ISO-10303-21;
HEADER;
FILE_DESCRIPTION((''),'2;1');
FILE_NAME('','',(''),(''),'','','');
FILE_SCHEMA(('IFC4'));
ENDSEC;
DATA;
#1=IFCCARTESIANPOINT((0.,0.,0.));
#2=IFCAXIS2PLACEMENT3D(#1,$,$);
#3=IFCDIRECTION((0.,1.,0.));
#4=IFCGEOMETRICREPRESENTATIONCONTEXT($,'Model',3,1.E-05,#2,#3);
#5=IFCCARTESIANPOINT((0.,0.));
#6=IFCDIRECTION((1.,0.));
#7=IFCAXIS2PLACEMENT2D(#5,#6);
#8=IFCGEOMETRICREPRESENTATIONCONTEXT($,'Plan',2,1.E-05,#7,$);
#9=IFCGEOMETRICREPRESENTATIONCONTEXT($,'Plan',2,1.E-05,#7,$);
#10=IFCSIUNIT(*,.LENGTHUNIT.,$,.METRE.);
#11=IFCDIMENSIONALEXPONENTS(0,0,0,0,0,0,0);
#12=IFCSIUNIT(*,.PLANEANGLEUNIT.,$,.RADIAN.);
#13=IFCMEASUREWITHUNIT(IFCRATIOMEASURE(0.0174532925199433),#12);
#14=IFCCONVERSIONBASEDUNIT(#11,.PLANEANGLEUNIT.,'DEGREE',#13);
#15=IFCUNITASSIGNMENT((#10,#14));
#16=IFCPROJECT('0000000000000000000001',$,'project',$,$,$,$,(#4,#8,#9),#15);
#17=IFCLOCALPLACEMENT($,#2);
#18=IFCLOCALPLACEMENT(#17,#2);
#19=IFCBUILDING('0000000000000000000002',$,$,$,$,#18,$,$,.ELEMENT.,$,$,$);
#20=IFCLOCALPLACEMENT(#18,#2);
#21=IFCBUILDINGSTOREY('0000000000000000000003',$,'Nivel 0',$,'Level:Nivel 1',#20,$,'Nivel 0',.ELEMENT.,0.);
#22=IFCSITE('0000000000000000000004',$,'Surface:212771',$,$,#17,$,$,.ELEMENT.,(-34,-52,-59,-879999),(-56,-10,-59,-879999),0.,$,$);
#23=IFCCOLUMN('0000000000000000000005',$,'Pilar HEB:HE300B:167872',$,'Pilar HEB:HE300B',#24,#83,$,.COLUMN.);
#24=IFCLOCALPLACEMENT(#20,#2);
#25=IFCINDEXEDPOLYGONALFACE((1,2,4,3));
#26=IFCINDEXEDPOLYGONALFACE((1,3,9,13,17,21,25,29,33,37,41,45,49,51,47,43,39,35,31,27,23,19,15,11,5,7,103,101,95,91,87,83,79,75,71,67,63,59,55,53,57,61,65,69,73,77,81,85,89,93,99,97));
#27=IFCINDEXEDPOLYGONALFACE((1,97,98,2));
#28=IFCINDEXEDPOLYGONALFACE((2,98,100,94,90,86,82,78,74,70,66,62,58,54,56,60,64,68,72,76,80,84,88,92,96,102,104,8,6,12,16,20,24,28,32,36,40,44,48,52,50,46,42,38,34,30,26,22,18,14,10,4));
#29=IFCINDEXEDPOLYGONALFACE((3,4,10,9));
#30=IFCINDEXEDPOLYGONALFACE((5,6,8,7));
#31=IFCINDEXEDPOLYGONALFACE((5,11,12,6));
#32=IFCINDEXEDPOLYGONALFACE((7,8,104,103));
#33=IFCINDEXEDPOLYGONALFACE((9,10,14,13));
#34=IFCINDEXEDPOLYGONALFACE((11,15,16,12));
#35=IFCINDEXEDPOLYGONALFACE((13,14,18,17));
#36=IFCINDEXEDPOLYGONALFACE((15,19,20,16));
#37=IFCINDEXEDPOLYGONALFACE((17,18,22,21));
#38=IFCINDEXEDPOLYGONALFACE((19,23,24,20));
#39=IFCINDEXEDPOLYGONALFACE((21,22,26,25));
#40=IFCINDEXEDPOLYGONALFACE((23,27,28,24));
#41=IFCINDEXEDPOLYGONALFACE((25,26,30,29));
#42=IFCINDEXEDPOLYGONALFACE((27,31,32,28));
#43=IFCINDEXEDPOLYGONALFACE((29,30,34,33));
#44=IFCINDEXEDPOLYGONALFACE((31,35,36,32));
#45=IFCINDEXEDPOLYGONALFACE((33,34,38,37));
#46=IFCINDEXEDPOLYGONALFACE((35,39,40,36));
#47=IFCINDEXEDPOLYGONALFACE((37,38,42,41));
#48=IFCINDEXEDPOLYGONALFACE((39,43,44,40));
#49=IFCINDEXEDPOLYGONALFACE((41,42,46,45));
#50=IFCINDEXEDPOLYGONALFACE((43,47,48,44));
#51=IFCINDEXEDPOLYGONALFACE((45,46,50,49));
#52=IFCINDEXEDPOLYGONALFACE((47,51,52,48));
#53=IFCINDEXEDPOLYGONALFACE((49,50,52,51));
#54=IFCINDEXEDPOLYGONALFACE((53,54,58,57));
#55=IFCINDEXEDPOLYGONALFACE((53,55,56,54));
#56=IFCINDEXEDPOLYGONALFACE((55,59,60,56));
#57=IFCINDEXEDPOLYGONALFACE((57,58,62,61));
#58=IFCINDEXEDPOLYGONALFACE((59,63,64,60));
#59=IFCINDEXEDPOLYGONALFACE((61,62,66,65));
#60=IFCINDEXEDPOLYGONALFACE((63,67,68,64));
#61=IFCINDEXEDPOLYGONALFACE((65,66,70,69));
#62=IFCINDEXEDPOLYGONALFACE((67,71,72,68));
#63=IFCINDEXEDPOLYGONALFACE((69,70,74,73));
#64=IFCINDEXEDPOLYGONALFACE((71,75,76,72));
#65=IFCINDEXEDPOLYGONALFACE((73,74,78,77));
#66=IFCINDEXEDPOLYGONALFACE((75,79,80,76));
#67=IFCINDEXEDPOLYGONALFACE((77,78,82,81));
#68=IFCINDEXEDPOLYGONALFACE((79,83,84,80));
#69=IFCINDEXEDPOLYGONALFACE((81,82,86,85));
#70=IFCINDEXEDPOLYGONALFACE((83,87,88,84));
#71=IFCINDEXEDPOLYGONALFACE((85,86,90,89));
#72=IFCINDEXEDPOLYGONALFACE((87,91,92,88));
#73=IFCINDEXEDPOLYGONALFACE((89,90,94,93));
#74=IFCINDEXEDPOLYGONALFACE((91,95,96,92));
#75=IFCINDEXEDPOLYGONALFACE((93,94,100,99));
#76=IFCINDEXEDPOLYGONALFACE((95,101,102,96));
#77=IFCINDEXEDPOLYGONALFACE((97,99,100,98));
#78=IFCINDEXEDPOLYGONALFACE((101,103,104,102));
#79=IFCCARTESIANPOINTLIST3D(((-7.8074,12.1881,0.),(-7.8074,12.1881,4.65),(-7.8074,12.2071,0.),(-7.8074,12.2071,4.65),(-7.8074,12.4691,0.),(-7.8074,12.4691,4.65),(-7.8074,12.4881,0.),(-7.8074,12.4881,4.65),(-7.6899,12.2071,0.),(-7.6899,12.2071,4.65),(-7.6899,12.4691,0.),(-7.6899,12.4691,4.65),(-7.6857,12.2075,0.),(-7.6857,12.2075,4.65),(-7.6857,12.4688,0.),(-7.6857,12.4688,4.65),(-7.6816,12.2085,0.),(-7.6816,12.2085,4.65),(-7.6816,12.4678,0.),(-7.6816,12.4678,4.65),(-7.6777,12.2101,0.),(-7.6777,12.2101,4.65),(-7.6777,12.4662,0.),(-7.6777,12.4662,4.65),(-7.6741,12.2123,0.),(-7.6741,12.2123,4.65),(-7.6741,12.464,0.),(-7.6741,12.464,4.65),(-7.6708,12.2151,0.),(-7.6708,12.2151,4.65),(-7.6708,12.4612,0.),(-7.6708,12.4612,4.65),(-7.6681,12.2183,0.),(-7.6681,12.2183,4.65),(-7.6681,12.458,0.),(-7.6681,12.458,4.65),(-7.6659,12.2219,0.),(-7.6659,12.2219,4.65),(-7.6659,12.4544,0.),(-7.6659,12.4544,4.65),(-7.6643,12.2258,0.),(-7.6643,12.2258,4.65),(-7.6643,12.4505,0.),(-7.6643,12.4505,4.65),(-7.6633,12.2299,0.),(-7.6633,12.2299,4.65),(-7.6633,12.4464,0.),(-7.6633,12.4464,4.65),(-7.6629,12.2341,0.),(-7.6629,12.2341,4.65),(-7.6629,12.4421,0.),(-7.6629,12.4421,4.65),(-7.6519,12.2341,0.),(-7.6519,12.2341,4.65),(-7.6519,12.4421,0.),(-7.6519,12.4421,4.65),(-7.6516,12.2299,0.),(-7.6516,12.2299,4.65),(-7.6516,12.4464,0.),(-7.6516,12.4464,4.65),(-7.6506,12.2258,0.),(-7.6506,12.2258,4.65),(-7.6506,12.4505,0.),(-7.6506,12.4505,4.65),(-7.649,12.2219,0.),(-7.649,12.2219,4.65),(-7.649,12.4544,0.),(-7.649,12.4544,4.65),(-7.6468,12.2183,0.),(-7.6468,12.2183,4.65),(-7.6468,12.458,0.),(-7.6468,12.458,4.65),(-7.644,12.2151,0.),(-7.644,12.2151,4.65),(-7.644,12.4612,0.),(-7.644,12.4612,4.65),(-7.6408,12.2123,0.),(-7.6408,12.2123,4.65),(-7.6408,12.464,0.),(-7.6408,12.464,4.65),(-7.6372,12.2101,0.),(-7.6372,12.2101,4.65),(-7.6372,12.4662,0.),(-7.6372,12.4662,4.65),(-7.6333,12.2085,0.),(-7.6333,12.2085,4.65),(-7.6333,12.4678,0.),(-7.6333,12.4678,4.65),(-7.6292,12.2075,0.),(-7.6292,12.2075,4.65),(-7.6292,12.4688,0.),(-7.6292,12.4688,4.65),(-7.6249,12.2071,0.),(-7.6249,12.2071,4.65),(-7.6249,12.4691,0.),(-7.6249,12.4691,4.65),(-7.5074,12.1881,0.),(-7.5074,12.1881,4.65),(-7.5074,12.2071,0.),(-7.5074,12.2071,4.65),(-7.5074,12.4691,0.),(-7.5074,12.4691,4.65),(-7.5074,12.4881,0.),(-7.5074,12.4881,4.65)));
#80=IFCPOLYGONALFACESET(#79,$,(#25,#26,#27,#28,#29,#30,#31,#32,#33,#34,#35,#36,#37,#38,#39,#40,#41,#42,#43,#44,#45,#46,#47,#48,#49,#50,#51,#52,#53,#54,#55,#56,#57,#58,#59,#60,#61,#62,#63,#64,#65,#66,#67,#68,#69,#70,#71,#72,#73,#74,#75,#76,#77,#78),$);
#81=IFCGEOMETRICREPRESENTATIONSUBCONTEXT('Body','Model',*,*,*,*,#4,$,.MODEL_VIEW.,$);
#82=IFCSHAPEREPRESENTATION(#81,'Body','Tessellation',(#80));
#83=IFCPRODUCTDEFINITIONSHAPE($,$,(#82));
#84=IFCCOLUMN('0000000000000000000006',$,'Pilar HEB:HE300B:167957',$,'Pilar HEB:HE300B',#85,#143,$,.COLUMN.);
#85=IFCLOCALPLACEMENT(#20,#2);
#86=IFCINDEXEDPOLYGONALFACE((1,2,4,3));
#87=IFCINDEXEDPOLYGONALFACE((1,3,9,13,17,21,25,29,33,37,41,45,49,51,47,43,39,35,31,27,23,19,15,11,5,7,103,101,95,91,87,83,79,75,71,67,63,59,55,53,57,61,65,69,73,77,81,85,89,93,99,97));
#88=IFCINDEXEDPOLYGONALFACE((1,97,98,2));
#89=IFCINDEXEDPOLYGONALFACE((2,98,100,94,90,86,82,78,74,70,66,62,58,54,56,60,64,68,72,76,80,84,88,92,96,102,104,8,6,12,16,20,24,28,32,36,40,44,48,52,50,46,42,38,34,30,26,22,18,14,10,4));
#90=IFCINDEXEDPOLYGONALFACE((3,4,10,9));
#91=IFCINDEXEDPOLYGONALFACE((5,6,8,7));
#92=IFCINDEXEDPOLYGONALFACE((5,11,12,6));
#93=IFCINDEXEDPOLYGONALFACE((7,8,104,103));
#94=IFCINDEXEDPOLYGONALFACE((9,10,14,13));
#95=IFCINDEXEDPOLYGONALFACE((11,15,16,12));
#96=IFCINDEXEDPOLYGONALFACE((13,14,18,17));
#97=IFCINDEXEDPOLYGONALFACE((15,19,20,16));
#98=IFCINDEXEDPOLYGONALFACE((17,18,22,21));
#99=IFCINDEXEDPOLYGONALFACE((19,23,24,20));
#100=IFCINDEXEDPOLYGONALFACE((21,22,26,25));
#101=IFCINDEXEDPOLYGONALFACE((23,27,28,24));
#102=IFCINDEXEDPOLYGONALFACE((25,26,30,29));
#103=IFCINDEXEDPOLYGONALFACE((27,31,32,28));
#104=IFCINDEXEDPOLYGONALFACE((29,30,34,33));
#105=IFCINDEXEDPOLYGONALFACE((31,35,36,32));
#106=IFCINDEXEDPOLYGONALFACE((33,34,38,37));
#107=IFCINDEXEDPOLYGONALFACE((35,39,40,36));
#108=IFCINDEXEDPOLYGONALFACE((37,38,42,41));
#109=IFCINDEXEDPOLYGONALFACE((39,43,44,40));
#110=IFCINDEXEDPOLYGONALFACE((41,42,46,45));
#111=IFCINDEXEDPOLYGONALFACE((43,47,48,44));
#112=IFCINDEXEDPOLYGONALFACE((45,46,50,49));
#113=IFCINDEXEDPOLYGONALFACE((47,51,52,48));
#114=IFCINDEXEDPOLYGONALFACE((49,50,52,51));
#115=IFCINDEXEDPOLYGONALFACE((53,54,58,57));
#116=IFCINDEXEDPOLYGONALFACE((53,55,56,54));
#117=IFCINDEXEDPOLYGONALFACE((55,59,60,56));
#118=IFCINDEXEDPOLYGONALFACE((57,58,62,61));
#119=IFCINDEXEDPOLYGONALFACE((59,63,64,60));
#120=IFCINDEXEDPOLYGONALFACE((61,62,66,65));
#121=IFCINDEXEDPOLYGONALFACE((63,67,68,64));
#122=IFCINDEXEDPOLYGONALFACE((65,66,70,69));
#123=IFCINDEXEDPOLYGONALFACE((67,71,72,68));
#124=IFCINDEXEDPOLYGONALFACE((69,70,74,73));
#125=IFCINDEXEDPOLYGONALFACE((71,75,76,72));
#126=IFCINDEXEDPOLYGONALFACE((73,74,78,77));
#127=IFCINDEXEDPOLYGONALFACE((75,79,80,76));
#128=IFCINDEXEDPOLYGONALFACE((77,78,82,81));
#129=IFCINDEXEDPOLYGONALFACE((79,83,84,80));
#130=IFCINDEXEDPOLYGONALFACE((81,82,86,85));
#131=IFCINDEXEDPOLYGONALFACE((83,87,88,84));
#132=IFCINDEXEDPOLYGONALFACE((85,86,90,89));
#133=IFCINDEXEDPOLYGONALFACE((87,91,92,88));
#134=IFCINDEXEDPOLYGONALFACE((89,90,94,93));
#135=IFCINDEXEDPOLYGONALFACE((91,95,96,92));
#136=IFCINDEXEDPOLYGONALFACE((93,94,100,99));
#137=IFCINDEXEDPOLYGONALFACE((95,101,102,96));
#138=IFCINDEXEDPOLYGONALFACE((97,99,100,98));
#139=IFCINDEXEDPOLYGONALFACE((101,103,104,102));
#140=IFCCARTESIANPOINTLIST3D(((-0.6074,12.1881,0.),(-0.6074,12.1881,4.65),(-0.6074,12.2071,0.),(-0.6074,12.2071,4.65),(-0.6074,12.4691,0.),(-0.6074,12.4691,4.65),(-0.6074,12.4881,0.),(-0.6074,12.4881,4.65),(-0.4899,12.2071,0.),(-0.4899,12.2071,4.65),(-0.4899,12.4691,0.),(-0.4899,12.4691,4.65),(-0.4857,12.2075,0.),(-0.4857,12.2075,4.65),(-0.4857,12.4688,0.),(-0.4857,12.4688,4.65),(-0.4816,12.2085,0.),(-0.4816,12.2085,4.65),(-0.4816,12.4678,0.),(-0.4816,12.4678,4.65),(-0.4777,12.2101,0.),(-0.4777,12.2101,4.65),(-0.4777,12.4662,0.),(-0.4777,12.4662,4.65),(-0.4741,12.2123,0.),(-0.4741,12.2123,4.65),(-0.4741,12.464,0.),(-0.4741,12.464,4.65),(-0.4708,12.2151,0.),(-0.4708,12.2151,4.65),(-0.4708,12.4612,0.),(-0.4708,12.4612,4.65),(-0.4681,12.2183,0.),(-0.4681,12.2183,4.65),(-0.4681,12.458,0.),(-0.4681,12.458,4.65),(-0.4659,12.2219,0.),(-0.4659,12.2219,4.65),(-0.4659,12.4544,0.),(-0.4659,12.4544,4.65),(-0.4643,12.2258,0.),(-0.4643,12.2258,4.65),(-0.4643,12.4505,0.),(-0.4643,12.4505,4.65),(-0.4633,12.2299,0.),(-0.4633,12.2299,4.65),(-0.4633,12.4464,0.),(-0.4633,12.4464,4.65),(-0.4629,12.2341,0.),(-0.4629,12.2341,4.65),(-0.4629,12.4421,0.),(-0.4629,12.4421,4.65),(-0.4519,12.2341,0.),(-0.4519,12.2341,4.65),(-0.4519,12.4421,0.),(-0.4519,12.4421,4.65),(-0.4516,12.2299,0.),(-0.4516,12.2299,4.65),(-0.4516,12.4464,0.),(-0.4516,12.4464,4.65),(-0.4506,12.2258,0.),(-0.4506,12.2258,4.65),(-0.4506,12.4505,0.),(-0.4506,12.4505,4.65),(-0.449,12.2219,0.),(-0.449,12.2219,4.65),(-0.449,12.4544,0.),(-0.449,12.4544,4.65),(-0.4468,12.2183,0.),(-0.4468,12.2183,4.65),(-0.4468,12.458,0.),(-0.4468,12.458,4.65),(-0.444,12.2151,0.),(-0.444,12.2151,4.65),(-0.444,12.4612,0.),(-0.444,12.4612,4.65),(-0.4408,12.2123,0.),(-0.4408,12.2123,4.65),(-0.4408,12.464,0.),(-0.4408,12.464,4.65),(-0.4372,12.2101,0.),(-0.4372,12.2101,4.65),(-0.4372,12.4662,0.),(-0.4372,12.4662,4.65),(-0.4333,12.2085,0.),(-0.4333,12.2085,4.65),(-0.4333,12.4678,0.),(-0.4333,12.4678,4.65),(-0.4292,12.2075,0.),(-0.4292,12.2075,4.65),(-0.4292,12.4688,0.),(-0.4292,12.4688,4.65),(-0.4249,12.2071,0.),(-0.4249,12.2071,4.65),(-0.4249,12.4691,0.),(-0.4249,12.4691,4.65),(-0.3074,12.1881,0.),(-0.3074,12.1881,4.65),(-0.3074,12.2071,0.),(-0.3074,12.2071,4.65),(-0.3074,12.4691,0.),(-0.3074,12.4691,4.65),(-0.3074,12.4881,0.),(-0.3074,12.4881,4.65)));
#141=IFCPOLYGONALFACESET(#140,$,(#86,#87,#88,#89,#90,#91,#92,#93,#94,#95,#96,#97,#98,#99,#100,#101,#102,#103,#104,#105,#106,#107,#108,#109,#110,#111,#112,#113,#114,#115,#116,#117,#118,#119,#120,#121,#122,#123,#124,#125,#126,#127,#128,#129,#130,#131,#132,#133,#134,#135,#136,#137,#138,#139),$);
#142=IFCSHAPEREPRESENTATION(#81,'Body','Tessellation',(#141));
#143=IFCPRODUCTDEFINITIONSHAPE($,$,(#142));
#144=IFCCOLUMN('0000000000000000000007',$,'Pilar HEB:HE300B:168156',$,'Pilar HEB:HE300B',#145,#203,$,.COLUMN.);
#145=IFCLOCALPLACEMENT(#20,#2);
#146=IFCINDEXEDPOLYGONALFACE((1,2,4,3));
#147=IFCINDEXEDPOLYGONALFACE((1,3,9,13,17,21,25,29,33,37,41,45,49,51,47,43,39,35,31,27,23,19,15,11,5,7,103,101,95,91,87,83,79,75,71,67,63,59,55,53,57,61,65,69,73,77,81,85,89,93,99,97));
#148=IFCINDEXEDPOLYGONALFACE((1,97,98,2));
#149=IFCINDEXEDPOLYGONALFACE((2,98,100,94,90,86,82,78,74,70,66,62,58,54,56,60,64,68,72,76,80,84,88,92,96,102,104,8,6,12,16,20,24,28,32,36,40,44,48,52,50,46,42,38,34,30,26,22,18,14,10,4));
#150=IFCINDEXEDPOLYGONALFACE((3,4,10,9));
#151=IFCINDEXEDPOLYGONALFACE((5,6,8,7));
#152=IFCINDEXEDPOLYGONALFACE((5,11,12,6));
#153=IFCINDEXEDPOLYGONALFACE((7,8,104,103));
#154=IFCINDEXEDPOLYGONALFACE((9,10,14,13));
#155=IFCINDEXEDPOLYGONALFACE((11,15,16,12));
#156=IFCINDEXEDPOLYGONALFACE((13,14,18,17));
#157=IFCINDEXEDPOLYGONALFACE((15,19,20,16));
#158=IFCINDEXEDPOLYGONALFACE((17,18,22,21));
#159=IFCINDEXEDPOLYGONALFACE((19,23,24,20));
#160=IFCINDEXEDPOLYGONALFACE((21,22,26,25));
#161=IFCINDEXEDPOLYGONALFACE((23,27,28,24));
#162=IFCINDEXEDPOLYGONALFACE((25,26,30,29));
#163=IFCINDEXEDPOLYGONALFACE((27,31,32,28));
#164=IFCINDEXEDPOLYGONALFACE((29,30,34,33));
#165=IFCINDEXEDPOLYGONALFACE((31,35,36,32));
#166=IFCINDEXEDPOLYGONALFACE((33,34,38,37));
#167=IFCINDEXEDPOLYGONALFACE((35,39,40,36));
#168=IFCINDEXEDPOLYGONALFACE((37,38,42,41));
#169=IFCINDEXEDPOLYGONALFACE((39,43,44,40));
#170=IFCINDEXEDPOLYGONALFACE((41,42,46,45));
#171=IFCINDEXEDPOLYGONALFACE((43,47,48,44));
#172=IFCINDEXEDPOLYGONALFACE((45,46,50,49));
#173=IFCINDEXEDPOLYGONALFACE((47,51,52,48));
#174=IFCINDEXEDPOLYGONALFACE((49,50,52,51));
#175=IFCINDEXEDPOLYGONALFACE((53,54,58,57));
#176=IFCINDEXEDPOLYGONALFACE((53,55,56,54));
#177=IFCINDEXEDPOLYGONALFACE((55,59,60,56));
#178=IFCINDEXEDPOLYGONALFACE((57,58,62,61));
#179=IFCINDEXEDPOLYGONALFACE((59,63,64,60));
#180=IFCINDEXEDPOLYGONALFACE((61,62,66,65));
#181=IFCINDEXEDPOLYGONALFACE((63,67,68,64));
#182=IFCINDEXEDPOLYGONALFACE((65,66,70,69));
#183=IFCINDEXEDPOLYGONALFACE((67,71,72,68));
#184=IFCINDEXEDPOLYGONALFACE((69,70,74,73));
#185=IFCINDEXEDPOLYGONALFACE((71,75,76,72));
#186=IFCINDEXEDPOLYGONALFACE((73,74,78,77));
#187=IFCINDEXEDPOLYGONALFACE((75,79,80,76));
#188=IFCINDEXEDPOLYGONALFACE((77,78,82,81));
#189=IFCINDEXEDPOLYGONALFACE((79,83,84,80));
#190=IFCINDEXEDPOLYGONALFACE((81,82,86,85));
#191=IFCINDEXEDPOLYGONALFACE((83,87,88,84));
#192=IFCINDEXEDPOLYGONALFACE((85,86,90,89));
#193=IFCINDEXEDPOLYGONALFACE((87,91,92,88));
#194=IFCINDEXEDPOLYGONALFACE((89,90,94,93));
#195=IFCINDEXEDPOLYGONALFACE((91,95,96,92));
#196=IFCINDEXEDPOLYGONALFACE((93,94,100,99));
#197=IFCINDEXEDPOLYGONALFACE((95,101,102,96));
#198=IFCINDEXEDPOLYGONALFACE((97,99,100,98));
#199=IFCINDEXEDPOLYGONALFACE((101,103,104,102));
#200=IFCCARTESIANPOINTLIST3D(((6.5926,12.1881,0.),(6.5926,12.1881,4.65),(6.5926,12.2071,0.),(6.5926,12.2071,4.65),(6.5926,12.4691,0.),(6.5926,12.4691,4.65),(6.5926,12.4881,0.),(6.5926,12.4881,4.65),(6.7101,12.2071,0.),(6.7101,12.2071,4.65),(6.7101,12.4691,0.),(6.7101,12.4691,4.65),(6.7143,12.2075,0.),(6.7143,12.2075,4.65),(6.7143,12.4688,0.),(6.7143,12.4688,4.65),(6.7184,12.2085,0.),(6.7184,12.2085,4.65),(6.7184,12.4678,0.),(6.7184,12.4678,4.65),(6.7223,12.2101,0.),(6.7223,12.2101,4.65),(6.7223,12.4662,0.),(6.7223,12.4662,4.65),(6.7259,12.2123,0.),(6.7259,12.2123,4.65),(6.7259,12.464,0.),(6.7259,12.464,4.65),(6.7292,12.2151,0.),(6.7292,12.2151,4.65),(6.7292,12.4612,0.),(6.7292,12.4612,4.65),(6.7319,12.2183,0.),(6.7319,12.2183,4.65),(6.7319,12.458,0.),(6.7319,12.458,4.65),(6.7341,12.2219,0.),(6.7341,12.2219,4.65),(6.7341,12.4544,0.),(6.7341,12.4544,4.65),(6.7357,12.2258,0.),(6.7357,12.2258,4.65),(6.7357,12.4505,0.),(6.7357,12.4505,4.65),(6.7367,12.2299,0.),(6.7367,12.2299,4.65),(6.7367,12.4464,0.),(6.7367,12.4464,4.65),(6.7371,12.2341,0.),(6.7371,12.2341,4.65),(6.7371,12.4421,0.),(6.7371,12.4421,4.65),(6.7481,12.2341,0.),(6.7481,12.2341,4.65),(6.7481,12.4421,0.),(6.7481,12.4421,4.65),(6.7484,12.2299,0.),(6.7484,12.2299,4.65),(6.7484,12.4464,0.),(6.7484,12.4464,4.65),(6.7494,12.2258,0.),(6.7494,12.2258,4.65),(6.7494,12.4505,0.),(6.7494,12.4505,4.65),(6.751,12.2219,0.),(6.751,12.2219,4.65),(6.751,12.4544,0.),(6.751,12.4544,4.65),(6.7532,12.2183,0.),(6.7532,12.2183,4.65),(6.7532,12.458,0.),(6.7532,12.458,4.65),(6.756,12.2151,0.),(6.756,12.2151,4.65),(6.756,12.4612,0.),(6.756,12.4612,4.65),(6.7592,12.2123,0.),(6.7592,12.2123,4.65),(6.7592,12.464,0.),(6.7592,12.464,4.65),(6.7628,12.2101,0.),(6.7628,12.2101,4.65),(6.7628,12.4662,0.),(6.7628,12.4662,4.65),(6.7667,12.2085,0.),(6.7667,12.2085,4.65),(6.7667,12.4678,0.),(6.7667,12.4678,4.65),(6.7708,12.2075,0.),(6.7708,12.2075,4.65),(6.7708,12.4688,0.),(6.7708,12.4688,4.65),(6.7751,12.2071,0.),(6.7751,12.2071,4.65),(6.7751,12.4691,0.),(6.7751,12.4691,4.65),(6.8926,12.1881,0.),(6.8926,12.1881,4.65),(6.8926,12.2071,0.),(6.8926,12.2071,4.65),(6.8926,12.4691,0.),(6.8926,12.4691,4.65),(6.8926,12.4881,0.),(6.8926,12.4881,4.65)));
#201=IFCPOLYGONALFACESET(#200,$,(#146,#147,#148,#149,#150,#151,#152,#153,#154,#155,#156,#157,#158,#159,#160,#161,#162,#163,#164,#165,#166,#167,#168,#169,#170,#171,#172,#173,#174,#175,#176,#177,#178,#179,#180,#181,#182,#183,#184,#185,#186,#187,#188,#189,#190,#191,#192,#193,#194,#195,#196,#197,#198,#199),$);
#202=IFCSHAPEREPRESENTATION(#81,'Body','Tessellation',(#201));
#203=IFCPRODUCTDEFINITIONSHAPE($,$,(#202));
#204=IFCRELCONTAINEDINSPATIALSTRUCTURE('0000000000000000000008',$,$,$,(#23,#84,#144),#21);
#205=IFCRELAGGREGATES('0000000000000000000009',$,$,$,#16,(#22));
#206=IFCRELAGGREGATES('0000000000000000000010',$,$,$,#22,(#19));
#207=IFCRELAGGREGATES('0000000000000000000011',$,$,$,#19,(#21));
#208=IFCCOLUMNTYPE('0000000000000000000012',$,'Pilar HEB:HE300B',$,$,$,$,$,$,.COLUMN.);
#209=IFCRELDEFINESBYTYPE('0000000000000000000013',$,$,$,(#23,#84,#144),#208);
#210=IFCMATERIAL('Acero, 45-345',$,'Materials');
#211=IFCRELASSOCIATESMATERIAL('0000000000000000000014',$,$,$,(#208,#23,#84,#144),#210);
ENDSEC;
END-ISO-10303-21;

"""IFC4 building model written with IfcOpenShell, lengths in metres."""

from ifc_helpers import new_model, entity, si_unit, converted_unit, direction, frame, origin, origin_2d_with_axis, place, context, subcontext, project, spatial, indexed_curve, outline, extrude, source, transform, mapped, material, type_object, type_shapes, element, save


model = new_model("IFC4")

# Units and contexts
model_context = context("Model", 3, precision=1e-05, world=origin(), true_north=direction((0.0, 1.0, 0.0)))
plan_context_1 = context("Plan", 2, precision=1e-05, world=origin_2d_with_axis())
plan_context_2 = context("Plan", 2, precision=1e-05, world=origin_2d_with_axis())
body_context = subcontext(model_context, "Body", "Model", "MODEL_VIEW")
ifc_project = project(units=[si_unit("LENGTHUNIT", "METRE"), converted_unit("PLANEANGLEUNIT", "DEGREE", entity("IfcRatioMeasure", 0.0174532925199433), si_unit("PLANEANGLEUNIT", "RADIAN"), dimensions=[0, 0, 0, 0, 0, 0, 0])], contexts=[model_context, plan_context_1, plan_context_2])

# Site, building, storey
site_placement = place(None, origin())
site = spatial("IfcSite", under=ifc_project, at=site_placement, Name="Surface:212771", CompositionType="ELEMENT", RefLatitude=(-34, -52, -59, -879999), RefLongitude=(-56, -10, -59, -879999), RefElevation=0.0)
building_placement = place(site_placement, origin())
building = spatial("IfcBuilding", under=site, at=building_placement, CompositionType="ELEMENT")
storey_placement = place(building_placement, origin())
storey = spatial("IfcBuildingStorey", under=building, at=storey_placement, Name="Nivel 0", ObjectType="Level:Nivel 1", LongName="Nivel 0", CompositionType="ELEMENT", Elevation=0.0)

# Columns
ifc_material_1 = material(Name="Acero, 45-345", Category="Materials")
column_type_1 = type_object("IfcColumnType", Name="Pilar HEB:HE300B", PredefinedType="COLUMN", material=ifc_material_1)
shared_shape_1 = source(origin(), body_context, "Body", "SweptSolid", [
    extrude(outline(indexed_curve([(-0.15, -0.15), (-0.131, -0.15), (-0.131, -0.0325), (-0.1307, -0.0283), (-0.1297, -0.0242), (-0.1281, -0.0202), (-0.1258, -0.0166), (-0.1231, -0.0134), (-0.1199, -0.0107), (-0.1163, -0.0084), (-0.1123, -0.0068), (-0.1082, -0.0058), (-0.104, -0.0055), (0.104, -0.0055), (0.1082, -0.0058), (0.1123, -0.0068), (0.1163, -0.0084), (0.1199, -0.0107), (0.1231, -0.0134), (0.1258, -0.0166), (0.1281, -0.0202), (0.1297, -0.0242), (0.1307, -0.0283), (0.131, -0.0325), (0.131, -0.15), (0.15, -0.15), (0.15, 0.15), (0.131, 0.15), (0.131, 0.0325), (0.1307, 0.0283), (0.1297, 0.0242), (0.1281, 0.0202), (0.1258, 0.0166), (0.1231, 0.0134), (0.1199, 0.0107), (0.1163, 0.0084), (0.1123, 0.0068), (0.1082, 0.0058), (0.104, 0.0055), (-0.104, 0.0055), (-0.1082, 0.0058), (-0.1123, 0.0068), (-0.1163, 0.0084), (-0.1199, 0.0107), (-0.1231, 0.0134), (-0.1258, 0.0166), (-0.1281, 0.0202), (-0.1297, 0.0242), (-0.1307, 0.0283), (-0.131, 0.0325), (-0.131, 0.15), (-0.15, 0.15), (-0.15, -0.15)], self_intersect=False)), frame((0.0, 0.0, 0.0), z_axis=(0.0, 0.0, 1.0), x_axis=(0.0, -1.0, 0.0)), (0.0, 0.0, 1.0), 4.65),
])
type_shapes(column_type_1, [shared_shape_1])
for number, where, name in (
    (1, (-7.6574, 12.3381, 0.0), "Pilar HEB:HE300B:167872"),
    (2, (-0.4574, 12.3381, 0.0), "Pilar HEB:HE300B:167957"),
    (3, (6.7426, 12.3381, 0.0), "Pilar HEB:HE300B:168156"),
):
    element("IfcColumn", number, at=place(storey_placement, frame(where)), inside=storey, type_object=column_type_1, material=ifc_material_1, Name=name, ObjectType="Pilar HEB:HE300B", PredefinedType="COLUMN", context=body_context, shape_type="MappedRepresentation", body=[
        mapped(shared_shape_1, transform((0.0, 0.0, 0.0), scale=1.0)),
    ])

save(model, "model.ifc")
